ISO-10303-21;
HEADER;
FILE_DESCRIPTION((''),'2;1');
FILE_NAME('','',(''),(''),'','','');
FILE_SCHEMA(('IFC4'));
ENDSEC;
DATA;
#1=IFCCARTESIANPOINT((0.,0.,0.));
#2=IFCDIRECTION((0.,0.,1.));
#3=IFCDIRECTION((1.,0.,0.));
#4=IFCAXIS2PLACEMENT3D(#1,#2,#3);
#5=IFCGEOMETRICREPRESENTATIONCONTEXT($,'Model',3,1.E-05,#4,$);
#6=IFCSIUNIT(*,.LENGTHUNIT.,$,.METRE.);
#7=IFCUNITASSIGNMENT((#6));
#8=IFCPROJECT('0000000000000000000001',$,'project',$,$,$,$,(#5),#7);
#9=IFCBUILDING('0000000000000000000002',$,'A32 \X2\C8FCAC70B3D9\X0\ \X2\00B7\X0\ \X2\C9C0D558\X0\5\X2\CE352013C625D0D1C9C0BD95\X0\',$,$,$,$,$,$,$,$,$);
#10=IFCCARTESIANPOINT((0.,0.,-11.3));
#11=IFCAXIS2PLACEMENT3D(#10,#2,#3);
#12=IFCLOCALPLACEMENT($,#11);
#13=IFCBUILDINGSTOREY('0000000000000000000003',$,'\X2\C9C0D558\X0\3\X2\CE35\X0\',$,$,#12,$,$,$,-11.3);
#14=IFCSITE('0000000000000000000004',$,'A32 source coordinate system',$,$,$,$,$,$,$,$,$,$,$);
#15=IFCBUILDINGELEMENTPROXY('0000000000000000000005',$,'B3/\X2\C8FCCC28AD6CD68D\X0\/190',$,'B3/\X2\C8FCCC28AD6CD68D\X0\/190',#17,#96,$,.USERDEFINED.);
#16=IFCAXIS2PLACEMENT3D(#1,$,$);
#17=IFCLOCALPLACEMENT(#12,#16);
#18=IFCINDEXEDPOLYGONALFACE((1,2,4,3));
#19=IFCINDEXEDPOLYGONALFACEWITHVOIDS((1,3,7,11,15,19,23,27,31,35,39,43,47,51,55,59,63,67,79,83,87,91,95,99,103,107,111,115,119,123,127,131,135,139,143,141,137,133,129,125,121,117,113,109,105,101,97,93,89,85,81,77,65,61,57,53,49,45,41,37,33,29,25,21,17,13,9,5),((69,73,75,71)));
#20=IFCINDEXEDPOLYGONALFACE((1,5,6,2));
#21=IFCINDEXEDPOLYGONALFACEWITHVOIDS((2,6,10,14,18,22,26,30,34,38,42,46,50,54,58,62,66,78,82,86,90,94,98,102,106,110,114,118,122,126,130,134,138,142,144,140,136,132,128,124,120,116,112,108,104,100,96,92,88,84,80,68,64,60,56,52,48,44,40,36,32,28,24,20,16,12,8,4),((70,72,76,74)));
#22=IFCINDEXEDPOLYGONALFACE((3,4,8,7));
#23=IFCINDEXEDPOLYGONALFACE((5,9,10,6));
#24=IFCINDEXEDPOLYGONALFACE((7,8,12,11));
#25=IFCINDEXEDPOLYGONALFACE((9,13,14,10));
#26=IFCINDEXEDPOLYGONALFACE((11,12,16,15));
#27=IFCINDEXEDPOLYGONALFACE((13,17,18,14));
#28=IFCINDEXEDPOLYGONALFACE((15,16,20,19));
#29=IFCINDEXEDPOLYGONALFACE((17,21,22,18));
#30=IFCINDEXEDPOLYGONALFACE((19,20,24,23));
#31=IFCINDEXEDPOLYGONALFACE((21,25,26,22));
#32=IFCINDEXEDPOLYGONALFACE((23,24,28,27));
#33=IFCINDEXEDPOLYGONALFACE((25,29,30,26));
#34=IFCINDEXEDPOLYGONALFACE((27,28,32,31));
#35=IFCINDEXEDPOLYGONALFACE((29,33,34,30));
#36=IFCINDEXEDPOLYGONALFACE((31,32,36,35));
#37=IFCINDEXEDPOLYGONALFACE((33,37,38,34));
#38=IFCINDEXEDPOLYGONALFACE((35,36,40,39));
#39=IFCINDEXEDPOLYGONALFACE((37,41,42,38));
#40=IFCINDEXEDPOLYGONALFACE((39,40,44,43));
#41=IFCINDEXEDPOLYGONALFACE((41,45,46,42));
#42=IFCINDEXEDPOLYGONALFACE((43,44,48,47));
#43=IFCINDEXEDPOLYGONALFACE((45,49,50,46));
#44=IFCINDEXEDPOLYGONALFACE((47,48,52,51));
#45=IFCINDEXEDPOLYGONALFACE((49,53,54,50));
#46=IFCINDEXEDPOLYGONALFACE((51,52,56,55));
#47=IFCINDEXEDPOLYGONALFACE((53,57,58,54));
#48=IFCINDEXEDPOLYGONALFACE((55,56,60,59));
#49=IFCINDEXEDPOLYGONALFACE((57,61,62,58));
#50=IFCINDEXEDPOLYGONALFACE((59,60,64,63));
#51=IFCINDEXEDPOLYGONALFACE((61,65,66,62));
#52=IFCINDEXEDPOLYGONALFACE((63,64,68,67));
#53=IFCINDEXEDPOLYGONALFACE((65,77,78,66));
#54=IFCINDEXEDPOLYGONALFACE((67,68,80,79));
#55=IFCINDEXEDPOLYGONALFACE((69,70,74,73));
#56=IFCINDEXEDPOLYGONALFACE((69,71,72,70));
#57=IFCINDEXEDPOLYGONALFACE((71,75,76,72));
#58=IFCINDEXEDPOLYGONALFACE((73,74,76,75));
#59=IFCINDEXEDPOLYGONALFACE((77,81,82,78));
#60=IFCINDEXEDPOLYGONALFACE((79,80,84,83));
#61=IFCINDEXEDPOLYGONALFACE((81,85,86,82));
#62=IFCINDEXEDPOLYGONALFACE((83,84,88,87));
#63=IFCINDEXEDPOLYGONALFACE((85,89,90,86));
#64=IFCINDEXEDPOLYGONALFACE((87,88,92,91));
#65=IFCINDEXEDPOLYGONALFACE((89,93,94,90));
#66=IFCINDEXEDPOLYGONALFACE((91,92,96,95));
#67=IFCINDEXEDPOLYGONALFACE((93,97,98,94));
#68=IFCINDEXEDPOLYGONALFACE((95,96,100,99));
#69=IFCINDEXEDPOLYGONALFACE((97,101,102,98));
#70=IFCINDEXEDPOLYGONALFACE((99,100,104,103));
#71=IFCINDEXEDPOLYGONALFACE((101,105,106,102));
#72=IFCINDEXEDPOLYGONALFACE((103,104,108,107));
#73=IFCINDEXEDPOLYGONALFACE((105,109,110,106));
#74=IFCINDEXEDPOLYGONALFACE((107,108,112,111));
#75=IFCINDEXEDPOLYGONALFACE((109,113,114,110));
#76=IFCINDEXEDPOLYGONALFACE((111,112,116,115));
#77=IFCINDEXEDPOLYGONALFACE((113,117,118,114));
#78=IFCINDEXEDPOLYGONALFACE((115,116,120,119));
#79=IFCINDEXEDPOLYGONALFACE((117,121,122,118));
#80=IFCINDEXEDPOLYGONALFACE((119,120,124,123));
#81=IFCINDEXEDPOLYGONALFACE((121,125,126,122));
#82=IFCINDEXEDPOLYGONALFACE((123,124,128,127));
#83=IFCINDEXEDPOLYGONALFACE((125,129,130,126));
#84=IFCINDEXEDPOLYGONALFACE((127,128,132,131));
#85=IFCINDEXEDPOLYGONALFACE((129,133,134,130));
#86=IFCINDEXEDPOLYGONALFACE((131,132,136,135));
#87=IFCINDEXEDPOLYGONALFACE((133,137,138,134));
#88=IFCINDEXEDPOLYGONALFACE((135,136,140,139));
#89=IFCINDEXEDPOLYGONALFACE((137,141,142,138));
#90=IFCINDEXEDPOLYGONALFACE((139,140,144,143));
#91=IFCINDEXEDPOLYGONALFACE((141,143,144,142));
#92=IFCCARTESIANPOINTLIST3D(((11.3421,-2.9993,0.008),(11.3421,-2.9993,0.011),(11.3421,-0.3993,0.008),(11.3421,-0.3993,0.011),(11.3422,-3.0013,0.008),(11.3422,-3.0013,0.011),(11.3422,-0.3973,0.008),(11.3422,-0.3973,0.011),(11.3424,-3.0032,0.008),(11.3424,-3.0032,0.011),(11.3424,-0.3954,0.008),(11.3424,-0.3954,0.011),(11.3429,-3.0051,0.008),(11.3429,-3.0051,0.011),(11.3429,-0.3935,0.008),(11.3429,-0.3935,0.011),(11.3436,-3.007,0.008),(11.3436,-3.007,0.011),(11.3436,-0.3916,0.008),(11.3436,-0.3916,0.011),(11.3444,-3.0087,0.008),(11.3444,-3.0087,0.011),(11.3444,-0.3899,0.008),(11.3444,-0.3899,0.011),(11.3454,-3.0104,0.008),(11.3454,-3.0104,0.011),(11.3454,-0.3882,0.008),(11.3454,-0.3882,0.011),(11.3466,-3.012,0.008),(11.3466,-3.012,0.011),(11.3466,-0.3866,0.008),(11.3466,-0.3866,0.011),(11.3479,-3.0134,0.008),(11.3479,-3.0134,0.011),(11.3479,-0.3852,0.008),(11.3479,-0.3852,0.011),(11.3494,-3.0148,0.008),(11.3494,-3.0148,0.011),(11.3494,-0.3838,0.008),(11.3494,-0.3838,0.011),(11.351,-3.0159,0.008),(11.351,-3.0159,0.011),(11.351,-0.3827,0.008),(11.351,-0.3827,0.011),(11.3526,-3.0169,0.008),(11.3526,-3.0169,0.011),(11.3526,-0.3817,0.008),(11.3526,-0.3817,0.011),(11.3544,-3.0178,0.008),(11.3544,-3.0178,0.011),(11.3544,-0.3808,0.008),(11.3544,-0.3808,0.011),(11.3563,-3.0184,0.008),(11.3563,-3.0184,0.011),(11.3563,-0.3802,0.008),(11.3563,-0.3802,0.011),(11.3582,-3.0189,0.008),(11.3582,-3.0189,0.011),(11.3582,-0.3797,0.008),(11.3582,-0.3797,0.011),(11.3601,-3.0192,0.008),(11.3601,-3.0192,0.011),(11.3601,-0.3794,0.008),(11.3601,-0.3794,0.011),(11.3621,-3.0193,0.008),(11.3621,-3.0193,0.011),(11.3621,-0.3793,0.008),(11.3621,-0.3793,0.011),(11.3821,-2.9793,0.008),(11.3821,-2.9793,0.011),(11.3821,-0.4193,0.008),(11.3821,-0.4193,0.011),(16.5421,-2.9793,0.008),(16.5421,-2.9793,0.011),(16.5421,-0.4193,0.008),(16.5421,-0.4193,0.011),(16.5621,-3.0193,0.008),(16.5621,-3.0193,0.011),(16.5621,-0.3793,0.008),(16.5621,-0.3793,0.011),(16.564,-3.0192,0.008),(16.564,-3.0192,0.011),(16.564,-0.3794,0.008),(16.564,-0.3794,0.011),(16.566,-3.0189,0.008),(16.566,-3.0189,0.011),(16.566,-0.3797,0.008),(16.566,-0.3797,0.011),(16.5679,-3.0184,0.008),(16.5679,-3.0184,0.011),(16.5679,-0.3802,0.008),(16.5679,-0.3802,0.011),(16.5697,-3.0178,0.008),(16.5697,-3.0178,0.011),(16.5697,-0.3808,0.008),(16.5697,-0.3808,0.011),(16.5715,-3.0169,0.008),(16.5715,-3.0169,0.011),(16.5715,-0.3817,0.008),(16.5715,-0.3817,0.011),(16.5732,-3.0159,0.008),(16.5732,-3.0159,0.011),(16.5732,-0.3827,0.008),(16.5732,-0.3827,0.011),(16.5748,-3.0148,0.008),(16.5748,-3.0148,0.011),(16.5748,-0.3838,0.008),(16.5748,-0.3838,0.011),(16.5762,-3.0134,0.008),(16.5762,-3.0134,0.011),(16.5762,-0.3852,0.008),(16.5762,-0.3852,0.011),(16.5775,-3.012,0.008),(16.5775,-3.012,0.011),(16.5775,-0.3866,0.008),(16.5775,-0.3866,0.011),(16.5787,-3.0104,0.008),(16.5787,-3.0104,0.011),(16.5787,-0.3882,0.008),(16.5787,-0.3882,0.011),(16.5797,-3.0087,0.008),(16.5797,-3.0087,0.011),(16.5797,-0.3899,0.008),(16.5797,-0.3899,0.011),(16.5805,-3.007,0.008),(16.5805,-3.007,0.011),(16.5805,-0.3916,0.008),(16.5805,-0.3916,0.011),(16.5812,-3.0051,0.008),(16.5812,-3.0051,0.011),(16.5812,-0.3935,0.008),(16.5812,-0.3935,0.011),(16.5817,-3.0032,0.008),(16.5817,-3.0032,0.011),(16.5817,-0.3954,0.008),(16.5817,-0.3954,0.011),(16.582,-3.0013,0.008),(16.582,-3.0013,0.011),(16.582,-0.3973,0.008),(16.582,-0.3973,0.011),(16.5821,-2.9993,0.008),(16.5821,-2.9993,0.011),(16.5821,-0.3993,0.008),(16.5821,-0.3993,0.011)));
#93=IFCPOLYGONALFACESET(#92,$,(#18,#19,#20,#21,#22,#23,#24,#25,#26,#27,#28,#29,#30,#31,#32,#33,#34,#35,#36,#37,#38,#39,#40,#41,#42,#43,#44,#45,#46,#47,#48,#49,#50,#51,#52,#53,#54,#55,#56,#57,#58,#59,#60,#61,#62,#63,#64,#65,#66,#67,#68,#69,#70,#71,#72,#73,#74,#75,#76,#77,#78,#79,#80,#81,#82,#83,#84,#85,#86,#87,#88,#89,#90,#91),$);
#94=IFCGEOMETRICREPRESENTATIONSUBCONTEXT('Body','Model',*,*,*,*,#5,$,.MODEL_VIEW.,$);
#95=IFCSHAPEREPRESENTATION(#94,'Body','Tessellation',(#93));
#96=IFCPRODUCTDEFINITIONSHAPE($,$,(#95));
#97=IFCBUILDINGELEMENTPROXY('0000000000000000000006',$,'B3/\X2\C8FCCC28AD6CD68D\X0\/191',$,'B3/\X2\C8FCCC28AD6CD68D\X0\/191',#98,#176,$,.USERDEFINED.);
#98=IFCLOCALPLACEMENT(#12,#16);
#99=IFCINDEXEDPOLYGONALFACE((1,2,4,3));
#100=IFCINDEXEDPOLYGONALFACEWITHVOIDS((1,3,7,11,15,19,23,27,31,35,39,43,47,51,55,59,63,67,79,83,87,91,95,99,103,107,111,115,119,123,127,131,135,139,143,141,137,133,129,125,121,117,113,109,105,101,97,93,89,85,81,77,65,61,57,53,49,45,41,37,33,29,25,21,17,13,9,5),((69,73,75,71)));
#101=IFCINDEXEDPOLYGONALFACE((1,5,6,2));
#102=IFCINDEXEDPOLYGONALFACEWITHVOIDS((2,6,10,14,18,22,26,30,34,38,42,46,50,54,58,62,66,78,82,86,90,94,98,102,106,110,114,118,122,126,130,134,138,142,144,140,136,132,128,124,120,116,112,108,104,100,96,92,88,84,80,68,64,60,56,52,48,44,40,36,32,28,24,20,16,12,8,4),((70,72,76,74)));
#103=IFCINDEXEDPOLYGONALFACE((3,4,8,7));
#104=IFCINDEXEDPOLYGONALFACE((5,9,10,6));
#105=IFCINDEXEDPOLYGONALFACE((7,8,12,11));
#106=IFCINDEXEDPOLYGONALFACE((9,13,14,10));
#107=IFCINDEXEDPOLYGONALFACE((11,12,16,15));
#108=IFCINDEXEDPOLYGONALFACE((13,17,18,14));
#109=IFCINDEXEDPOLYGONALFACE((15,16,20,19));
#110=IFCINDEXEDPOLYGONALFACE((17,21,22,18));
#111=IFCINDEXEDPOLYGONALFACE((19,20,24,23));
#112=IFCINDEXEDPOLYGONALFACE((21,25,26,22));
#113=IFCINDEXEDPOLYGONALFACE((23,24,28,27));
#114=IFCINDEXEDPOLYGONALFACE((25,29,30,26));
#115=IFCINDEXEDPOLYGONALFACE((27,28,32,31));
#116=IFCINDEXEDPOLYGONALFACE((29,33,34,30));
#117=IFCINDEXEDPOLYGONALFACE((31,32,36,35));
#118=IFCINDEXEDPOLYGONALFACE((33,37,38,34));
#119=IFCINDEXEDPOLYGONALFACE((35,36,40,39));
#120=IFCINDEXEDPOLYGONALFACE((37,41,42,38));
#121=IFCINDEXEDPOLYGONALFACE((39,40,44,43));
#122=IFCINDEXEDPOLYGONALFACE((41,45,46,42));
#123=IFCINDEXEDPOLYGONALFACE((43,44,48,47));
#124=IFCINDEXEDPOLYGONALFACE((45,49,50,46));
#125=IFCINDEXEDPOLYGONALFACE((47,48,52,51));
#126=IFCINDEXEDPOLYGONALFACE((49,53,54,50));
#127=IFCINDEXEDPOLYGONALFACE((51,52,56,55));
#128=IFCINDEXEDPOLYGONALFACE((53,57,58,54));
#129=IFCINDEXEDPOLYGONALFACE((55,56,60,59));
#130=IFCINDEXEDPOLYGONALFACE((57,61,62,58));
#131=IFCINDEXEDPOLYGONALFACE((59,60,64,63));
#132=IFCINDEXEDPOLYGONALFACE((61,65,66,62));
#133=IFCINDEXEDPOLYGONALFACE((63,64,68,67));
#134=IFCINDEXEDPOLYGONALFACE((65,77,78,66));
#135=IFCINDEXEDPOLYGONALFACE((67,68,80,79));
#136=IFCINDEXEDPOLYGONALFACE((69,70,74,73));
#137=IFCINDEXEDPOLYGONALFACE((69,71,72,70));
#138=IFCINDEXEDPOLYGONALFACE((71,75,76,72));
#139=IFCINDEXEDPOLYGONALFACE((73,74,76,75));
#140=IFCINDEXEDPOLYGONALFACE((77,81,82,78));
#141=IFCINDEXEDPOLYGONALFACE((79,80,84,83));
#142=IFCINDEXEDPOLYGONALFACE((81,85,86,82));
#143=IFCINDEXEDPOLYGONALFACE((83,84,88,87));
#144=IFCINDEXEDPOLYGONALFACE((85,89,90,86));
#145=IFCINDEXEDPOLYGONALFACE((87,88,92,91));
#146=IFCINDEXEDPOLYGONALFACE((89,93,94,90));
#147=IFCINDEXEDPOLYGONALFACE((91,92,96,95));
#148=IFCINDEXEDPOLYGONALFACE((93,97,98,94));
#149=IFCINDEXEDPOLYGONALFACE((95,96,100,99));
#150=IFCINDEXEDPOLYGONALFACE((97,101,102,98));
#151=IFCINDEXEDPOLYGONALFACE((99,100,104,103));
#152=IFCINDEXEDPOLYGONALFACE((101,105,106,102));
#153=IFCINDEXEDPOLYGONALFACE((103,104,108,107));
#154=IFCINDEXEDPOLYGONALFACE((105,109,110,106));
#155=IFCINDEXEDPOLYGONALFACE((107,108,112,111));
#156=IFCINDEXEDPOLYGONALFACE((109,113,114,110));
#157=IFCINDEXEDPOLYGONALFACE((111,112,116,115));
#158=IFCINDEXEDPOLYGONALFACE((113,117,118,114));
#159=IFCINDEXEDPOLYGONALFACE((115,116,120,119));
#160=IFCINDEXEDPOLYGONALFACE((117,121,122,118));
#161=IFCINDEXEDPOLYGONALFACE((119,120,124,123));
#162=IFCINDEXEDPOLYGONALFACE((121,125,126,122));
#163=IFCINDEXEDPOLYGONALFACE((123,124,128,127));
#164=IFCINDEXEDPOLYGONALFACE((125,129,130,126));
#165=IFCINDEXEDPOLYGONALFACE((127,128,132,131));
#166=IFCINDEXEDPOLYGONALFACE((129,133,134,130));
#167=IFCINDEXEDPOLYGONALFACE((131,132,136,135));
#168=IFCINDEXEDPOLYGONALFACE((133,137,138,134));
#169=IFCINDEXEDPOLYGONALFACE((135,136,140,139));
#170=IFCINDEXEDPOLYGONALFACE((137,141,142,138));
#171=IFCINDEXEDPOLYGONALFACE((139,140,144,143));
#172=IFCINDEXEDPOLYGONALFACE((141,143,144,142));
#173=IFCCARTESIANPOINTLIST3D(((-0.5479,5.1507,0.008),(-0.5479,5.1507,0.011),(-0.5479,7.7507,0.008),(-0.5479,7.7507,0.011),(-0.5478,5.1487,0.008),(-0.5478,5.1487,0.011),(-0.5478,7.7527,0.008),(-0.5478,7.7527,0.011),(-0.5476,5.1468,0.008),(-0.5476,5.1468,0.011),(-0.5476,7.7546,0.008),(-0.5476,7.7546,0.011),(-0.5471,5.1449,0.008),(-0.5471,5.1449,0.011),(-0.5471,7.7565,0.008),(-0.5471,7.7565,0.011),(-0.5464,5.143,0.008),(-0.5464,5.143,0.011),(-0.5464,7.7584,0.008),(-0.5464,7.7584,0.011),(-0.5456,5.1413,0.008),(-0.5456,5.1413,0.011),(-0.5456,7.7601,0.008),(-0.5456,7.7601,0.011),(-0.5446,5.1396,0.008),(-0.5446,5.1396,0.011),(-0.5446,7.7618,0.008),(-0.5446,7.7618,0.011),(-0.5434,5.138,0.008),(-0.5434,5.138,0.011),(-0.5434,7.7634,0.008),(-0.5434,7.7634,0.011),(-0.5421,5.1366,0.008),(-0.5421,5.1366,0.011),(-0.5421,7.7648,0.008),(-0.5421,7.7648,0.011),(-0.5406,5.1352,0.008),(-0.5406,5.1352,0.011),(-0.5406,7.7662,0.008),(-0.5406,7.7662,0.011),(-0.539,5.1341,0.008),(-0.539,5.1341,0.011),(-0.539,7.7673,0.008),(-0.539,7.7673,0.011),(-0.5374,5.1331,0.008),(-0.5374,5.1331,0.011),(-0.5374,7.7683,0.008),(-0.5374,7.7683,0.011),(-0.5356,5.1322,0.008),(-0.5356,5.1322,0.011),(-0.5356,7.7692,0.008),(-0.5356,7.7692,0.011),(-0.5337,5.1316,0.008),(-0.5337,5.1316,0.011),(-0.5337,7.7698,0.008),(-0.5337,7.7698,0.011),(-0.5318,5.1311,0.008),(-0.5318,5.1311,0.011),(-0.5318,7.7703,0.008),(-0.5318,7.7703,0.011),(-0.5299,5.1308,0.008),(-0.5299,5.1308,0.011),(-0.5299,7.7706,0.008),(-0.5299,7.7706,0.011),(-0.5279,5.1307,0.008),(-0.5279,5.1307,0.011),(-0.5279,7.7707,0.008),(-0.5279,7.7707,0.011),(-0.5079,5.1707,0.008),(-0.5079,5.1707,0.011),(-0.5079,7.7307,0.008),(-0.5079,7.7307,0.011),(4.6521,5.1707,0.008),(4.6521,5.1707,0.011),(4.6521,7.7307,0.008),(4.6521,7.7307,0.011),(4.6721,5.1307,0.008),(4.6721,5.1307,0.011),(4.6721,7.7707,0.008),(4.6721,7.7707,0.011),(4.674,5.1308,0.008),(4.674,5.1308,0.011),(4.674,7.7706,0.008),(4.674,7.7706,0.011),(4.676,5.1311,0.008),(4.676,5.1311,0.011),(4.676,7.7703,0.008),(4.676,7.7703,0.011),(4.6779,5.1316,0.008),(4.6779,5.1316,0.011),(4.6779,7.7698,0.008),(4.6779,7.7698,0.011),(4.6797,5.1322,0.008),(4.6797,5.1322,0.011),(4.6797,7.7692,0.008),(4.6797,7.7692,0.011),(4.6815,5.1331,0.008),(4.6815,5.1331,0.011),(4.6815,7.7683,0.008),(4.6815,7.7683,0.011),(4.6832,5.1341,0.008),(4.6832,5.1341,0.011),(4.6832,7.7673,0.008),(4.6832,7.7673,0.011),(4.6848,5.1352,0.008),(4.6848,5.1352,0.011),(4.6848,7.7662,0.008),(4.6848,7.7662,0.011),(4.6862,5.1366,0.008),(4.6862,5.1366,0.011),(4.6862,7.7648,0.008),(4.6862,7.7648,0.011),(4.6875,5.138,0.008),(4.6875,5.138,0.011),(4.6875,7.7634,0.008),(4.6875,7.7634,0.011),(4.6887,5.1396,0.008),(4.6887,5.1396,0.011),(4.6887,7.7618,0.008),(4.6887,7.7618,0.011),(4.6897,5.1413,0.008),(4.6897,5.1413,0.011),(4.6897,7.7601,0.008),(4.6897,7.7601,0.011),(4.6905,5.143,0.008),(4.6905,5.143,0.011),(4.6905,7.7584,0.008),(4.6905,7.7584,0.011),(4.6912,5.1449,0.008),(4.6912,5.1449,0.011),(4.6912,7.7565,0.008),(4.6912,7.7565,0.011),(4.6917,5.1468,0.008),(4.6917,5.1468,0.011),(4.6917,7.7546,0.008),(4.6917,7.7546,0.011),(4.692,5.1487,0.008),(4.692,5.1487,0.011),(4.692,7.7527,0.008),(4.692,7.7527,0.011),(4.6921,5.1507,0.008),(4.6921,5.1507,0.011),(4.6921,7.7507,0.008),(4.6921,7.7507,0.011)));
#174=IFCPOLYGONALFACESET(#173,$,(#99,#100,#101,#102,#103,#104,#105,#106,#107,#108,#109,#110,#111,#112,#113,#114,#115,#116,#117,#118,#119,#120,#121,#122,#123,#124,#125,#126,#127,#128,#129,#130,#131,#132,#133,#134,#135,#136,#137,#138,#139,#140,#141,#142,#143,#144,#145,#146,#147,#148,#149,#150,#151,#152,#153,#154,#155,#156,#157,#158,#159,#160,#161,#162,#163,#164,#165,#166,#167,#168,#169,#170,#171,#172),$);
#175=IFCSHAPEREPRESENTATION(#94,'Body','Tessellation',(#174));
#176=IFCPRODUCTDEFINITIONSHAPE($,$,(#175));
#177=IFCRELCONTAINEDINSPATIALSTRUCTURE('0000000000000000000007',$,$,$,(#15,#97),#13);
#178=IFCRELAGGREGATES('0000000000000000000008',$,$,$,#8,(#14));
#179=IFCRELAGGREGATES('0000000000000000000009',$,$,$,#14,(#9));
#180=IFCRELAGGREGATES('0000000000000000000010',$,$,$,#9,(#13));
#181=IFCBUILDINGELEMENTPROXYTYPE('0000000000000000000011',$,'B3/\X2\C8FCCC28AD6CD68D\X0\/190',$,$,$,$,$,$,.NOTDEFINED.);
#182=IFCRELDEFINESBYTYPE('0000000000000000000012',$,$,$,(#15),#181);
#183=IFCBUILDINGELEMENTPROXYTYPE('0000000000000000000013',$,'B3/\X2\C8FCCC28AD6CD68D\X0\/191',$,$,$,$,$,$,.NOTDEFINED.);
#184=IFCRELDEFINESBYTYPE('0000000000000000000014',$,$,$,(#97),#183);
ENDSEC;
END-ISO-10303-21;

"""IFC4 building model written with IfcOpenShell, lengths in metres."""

from ifc_helpers import new_model, si_unit, frame, origin, origin_with_axes, place, context, subcontext, project, spatial, polyline, outline, extrude, source, transform, mapped, type_object, type_shapes, element, save


model = new_model("IFC4")

# Units and contexts
model_context = context("Model", 3, precision=1e-05, world=origin_with_axes())
body_context = subcontext(model_context, "Body", "Model", "MODEL_VIEW")
ifc_project = project(units=[si_unit("LENGTHUNIT", "METRE")], contexts=[model_context])

# Site, building, storey
site = spatial("IfcSite", under=ifc_project, Name="A32 source coordinate system")
building = spatial("IfcBuilding", under=site, Name="A32 주거동 · 지하5층–옥탑지붕")
storey_placement = place(None, frame((0.0, 0.0, -11.3), z_axis=(0.0, 0.0, 1.0), x_axis=(1.0, 0.0, 0.0)))
storey = spatial("IfcBuildingStorey", under=building, at=storey_placement, Name="지하3층", Elevation=-11.3)

# Building element proxies
building_element_proxy_type_1 = type_object("IfcBuildingElementProxyType", Name="B3/주차구획/190", PredefinedType="NOTDEFINED")
shared_shape_1 = source(origin(), body_context, "Body", "SweptSolid", [
    extrude(outline(polyline([(16.5621, -0.3793), (16.564, -0.3794), (16.566, -0.3797), (16.5679, -0.3802), (16.5697, -0.3808), (16.5715, -0.3817), (16.5732, -0.3827), (16.5748, -0.3838), (16.5762, -0.3852), (16.5775, -0.3866), (16.5787, -0.3882), (16.5797, -0.3899), (16.5805, -0.3916), (16.5812, -0.3935), (16.5817, -0.3954), (16.582, -0.3973), (16.5821, -0.3993), (16.5821, -2.9993), (16.582, -3.0013), (16.5817, -3.0032), (16.5812, -3.0051), (16.5805, -3.007), (16.5797, -3.0087), (16.5787, -3.0104), (16.5775, -3.012), (16.5762, -3.0134), (16.5748, -3.0148), (16.5732, -3.0159), (16.5715, -3.0169), (16.5697, -3.0178), (16.5679, -3.0184), (16.566, -3.0189), (16.564, -3.0192), (16.5621, -3.0193), (11.3621, -3.0193), (11.3601, -3.0192), (11.3582, -3.0189), (11.3563, -3.0184), (11.3544, -3.0178), (11.3526, -3.0169), (11.351, -3.0159), (11.3494, -3.0148), (11.3479, -3.0134), (11.3466, -3.012), (11.3454, -3.0104), (11.3444, -3.0087), (11.3436, -3.007), (11.3429, -3.0051), (11.3424, -3.0032), (11.3422, -3.0013), (11.3421, -2.9993), (11.3421, -0.3993), (11.3422, -0.3973), (11.3424, -0.3954), (11.3429, -0.3935), (11.3436, -0.3916), (11.3444, -0.3899), (11.3454, -0.3882), (11.3466, -0.3866), (11.3479, -0.3852), (11.3494, -0.3838), (11.351, -0.3827), (11.3526, -0.3817), (11.3544, -0.3808), (11.3563, -0.3802), (11.3582, -0.3797), (11.3601, -0.3794), (11.3621, -0.3793), (16.5621, -0.3793)]), holes=[polyline([(16.5421, -0.4193), (11.3821, -0.4193), (11.3821, -2.9793), (16.5421, -2.9793), (16.5421, -0.4193)])]), frame((0.0, 0.0, 0.008)), (0.0, 0.0, 1.0), 0.003),
])
type_shapes(building_element_proxy_type_1, [shared_shape_1])
proxy_1_placement = place(storey_placement, origin_with_axes())
element("IfcBuildingElementProxy", 1, at=proxy_1_placement, inside=storey, type_object=building_element_proxy_type_1, Name="B3/주차구획/190", ObjectType="B3/주차구획/190", PredefinedType="USERDEFINED", context=body_context, shape_type="MappedRepresentation", body=[
    mapped(shared_shape_1, transform((0.0, 0.0, 0.0), scale=1.0)),
])
building_element_proxy_type_2 = type_object("IfcBuildingElementProxyType", Name="B3/주차구획/191", PredefinedType="NOTDEFINED")
shared_shape_2 = source(origin(), body_context, "Body", "SweptSolid", [
    extrude(outline(polyline([(-0.5279, 5.1307), (-0.5299, 5.1308), (-0.5318, 5.1311), (-0.5337, 5.1316), (-0.5356, 5.1322), (-0.5374, 5.1331), (-0.539, 5.1341), (-0.5406, 5.1352), (-0.5421, 5.1366), (-0.5434, 5.138), (-0.5446, 5.1396), (-0.5456, 5.1413), (-0.5464, 5.143), (-0.5471, 5.1449), (-0.5476, 5.1468), (-0.5478, 5.1487), (-0.5479, 5.1507), (-0.5479, 7.7507), (-0.5478, 7.7527), (-0.5476, 7.7546), (-0.5471, 7.7565), (-0.5464, 7.7584), (-0.5456, 7.7601), (-0.5446, 7.7618), (-0.5434, 7.7634), (-0.5421, 7.7648), (-0.5406, 7.7662), (-0.539, 7.7673), (-0.5374, 7.7683), (-0.5356, 7.7692), (-0.5337, 7.7698), (-0.5318, 7.7703), (-0.5299, 7.7706), (-0.5279, 7.7707), (4.6721, 7.7707), (4.674, 7.7706), (4.676, 7.7703), (4.6779, 7.7698), (4.6797, 7.7692), (4.6815, 7.7683), (4.6832, 7.7673), (4.6848, 7.7662), (4.6862, 7.7648), (4.6875, 7.7634), (4.6887, 7.7618), (4.6897, 7.7601), (4.6905, 7.7584), (4.6912, 7.7565), (4.6917, 7.7546), (4.692, 7.7527), (4.6921, 7.7507), (4.6921, 5.1507), (4.692, 5.1487), (4.6917, 5.1468), (4.6912, 5.1449), (4.6905, 5.143), (4.6897, 5.1413), (4.6887, 5.1396), (4.6875, 5.138), (4.6862, 5.1366), (4.6848, 5.1352), (4.6832, 5.1341), (4.6815, 5.1331), (4.6797, 5.1322), (4.6779, 5.1316), (4.676, 5.1311), (4.674, 5.1308), (4.6721, 5.1307), (-0.5279, 5.1307)]), holes=[polyline([(-0.5079, 5.1707), (4.6521, 5.1707), (4.6521, 7.7307), (-0.5079, 7.7307), (-0.5079, 5.1707)])]), frame((0.0, 0.0, 0.008)), (0.0, 0.0, 1.0), 0.003),
])
type_shapes(building_element_proxy_type_2, [shared_shape_2])
proxy_2_placement = place(storey_placement, origin_with_axes())
element("IfcBuildingElementProxy", 2, at=proxy_2_placement, inside=storey, type_object=building_element_proxy_type_2, Name="B3/주차구획/191", ObjectType="B3/주차구획/191", PredefinedType="USERDEFINED", context=body_context, shape_type="MappedRepresentation", body=[
    mapped(shared_shape_2, transform((0.0, 0.0, 0.0), scale=1.0)),
])

save(model, "model.ifc")
